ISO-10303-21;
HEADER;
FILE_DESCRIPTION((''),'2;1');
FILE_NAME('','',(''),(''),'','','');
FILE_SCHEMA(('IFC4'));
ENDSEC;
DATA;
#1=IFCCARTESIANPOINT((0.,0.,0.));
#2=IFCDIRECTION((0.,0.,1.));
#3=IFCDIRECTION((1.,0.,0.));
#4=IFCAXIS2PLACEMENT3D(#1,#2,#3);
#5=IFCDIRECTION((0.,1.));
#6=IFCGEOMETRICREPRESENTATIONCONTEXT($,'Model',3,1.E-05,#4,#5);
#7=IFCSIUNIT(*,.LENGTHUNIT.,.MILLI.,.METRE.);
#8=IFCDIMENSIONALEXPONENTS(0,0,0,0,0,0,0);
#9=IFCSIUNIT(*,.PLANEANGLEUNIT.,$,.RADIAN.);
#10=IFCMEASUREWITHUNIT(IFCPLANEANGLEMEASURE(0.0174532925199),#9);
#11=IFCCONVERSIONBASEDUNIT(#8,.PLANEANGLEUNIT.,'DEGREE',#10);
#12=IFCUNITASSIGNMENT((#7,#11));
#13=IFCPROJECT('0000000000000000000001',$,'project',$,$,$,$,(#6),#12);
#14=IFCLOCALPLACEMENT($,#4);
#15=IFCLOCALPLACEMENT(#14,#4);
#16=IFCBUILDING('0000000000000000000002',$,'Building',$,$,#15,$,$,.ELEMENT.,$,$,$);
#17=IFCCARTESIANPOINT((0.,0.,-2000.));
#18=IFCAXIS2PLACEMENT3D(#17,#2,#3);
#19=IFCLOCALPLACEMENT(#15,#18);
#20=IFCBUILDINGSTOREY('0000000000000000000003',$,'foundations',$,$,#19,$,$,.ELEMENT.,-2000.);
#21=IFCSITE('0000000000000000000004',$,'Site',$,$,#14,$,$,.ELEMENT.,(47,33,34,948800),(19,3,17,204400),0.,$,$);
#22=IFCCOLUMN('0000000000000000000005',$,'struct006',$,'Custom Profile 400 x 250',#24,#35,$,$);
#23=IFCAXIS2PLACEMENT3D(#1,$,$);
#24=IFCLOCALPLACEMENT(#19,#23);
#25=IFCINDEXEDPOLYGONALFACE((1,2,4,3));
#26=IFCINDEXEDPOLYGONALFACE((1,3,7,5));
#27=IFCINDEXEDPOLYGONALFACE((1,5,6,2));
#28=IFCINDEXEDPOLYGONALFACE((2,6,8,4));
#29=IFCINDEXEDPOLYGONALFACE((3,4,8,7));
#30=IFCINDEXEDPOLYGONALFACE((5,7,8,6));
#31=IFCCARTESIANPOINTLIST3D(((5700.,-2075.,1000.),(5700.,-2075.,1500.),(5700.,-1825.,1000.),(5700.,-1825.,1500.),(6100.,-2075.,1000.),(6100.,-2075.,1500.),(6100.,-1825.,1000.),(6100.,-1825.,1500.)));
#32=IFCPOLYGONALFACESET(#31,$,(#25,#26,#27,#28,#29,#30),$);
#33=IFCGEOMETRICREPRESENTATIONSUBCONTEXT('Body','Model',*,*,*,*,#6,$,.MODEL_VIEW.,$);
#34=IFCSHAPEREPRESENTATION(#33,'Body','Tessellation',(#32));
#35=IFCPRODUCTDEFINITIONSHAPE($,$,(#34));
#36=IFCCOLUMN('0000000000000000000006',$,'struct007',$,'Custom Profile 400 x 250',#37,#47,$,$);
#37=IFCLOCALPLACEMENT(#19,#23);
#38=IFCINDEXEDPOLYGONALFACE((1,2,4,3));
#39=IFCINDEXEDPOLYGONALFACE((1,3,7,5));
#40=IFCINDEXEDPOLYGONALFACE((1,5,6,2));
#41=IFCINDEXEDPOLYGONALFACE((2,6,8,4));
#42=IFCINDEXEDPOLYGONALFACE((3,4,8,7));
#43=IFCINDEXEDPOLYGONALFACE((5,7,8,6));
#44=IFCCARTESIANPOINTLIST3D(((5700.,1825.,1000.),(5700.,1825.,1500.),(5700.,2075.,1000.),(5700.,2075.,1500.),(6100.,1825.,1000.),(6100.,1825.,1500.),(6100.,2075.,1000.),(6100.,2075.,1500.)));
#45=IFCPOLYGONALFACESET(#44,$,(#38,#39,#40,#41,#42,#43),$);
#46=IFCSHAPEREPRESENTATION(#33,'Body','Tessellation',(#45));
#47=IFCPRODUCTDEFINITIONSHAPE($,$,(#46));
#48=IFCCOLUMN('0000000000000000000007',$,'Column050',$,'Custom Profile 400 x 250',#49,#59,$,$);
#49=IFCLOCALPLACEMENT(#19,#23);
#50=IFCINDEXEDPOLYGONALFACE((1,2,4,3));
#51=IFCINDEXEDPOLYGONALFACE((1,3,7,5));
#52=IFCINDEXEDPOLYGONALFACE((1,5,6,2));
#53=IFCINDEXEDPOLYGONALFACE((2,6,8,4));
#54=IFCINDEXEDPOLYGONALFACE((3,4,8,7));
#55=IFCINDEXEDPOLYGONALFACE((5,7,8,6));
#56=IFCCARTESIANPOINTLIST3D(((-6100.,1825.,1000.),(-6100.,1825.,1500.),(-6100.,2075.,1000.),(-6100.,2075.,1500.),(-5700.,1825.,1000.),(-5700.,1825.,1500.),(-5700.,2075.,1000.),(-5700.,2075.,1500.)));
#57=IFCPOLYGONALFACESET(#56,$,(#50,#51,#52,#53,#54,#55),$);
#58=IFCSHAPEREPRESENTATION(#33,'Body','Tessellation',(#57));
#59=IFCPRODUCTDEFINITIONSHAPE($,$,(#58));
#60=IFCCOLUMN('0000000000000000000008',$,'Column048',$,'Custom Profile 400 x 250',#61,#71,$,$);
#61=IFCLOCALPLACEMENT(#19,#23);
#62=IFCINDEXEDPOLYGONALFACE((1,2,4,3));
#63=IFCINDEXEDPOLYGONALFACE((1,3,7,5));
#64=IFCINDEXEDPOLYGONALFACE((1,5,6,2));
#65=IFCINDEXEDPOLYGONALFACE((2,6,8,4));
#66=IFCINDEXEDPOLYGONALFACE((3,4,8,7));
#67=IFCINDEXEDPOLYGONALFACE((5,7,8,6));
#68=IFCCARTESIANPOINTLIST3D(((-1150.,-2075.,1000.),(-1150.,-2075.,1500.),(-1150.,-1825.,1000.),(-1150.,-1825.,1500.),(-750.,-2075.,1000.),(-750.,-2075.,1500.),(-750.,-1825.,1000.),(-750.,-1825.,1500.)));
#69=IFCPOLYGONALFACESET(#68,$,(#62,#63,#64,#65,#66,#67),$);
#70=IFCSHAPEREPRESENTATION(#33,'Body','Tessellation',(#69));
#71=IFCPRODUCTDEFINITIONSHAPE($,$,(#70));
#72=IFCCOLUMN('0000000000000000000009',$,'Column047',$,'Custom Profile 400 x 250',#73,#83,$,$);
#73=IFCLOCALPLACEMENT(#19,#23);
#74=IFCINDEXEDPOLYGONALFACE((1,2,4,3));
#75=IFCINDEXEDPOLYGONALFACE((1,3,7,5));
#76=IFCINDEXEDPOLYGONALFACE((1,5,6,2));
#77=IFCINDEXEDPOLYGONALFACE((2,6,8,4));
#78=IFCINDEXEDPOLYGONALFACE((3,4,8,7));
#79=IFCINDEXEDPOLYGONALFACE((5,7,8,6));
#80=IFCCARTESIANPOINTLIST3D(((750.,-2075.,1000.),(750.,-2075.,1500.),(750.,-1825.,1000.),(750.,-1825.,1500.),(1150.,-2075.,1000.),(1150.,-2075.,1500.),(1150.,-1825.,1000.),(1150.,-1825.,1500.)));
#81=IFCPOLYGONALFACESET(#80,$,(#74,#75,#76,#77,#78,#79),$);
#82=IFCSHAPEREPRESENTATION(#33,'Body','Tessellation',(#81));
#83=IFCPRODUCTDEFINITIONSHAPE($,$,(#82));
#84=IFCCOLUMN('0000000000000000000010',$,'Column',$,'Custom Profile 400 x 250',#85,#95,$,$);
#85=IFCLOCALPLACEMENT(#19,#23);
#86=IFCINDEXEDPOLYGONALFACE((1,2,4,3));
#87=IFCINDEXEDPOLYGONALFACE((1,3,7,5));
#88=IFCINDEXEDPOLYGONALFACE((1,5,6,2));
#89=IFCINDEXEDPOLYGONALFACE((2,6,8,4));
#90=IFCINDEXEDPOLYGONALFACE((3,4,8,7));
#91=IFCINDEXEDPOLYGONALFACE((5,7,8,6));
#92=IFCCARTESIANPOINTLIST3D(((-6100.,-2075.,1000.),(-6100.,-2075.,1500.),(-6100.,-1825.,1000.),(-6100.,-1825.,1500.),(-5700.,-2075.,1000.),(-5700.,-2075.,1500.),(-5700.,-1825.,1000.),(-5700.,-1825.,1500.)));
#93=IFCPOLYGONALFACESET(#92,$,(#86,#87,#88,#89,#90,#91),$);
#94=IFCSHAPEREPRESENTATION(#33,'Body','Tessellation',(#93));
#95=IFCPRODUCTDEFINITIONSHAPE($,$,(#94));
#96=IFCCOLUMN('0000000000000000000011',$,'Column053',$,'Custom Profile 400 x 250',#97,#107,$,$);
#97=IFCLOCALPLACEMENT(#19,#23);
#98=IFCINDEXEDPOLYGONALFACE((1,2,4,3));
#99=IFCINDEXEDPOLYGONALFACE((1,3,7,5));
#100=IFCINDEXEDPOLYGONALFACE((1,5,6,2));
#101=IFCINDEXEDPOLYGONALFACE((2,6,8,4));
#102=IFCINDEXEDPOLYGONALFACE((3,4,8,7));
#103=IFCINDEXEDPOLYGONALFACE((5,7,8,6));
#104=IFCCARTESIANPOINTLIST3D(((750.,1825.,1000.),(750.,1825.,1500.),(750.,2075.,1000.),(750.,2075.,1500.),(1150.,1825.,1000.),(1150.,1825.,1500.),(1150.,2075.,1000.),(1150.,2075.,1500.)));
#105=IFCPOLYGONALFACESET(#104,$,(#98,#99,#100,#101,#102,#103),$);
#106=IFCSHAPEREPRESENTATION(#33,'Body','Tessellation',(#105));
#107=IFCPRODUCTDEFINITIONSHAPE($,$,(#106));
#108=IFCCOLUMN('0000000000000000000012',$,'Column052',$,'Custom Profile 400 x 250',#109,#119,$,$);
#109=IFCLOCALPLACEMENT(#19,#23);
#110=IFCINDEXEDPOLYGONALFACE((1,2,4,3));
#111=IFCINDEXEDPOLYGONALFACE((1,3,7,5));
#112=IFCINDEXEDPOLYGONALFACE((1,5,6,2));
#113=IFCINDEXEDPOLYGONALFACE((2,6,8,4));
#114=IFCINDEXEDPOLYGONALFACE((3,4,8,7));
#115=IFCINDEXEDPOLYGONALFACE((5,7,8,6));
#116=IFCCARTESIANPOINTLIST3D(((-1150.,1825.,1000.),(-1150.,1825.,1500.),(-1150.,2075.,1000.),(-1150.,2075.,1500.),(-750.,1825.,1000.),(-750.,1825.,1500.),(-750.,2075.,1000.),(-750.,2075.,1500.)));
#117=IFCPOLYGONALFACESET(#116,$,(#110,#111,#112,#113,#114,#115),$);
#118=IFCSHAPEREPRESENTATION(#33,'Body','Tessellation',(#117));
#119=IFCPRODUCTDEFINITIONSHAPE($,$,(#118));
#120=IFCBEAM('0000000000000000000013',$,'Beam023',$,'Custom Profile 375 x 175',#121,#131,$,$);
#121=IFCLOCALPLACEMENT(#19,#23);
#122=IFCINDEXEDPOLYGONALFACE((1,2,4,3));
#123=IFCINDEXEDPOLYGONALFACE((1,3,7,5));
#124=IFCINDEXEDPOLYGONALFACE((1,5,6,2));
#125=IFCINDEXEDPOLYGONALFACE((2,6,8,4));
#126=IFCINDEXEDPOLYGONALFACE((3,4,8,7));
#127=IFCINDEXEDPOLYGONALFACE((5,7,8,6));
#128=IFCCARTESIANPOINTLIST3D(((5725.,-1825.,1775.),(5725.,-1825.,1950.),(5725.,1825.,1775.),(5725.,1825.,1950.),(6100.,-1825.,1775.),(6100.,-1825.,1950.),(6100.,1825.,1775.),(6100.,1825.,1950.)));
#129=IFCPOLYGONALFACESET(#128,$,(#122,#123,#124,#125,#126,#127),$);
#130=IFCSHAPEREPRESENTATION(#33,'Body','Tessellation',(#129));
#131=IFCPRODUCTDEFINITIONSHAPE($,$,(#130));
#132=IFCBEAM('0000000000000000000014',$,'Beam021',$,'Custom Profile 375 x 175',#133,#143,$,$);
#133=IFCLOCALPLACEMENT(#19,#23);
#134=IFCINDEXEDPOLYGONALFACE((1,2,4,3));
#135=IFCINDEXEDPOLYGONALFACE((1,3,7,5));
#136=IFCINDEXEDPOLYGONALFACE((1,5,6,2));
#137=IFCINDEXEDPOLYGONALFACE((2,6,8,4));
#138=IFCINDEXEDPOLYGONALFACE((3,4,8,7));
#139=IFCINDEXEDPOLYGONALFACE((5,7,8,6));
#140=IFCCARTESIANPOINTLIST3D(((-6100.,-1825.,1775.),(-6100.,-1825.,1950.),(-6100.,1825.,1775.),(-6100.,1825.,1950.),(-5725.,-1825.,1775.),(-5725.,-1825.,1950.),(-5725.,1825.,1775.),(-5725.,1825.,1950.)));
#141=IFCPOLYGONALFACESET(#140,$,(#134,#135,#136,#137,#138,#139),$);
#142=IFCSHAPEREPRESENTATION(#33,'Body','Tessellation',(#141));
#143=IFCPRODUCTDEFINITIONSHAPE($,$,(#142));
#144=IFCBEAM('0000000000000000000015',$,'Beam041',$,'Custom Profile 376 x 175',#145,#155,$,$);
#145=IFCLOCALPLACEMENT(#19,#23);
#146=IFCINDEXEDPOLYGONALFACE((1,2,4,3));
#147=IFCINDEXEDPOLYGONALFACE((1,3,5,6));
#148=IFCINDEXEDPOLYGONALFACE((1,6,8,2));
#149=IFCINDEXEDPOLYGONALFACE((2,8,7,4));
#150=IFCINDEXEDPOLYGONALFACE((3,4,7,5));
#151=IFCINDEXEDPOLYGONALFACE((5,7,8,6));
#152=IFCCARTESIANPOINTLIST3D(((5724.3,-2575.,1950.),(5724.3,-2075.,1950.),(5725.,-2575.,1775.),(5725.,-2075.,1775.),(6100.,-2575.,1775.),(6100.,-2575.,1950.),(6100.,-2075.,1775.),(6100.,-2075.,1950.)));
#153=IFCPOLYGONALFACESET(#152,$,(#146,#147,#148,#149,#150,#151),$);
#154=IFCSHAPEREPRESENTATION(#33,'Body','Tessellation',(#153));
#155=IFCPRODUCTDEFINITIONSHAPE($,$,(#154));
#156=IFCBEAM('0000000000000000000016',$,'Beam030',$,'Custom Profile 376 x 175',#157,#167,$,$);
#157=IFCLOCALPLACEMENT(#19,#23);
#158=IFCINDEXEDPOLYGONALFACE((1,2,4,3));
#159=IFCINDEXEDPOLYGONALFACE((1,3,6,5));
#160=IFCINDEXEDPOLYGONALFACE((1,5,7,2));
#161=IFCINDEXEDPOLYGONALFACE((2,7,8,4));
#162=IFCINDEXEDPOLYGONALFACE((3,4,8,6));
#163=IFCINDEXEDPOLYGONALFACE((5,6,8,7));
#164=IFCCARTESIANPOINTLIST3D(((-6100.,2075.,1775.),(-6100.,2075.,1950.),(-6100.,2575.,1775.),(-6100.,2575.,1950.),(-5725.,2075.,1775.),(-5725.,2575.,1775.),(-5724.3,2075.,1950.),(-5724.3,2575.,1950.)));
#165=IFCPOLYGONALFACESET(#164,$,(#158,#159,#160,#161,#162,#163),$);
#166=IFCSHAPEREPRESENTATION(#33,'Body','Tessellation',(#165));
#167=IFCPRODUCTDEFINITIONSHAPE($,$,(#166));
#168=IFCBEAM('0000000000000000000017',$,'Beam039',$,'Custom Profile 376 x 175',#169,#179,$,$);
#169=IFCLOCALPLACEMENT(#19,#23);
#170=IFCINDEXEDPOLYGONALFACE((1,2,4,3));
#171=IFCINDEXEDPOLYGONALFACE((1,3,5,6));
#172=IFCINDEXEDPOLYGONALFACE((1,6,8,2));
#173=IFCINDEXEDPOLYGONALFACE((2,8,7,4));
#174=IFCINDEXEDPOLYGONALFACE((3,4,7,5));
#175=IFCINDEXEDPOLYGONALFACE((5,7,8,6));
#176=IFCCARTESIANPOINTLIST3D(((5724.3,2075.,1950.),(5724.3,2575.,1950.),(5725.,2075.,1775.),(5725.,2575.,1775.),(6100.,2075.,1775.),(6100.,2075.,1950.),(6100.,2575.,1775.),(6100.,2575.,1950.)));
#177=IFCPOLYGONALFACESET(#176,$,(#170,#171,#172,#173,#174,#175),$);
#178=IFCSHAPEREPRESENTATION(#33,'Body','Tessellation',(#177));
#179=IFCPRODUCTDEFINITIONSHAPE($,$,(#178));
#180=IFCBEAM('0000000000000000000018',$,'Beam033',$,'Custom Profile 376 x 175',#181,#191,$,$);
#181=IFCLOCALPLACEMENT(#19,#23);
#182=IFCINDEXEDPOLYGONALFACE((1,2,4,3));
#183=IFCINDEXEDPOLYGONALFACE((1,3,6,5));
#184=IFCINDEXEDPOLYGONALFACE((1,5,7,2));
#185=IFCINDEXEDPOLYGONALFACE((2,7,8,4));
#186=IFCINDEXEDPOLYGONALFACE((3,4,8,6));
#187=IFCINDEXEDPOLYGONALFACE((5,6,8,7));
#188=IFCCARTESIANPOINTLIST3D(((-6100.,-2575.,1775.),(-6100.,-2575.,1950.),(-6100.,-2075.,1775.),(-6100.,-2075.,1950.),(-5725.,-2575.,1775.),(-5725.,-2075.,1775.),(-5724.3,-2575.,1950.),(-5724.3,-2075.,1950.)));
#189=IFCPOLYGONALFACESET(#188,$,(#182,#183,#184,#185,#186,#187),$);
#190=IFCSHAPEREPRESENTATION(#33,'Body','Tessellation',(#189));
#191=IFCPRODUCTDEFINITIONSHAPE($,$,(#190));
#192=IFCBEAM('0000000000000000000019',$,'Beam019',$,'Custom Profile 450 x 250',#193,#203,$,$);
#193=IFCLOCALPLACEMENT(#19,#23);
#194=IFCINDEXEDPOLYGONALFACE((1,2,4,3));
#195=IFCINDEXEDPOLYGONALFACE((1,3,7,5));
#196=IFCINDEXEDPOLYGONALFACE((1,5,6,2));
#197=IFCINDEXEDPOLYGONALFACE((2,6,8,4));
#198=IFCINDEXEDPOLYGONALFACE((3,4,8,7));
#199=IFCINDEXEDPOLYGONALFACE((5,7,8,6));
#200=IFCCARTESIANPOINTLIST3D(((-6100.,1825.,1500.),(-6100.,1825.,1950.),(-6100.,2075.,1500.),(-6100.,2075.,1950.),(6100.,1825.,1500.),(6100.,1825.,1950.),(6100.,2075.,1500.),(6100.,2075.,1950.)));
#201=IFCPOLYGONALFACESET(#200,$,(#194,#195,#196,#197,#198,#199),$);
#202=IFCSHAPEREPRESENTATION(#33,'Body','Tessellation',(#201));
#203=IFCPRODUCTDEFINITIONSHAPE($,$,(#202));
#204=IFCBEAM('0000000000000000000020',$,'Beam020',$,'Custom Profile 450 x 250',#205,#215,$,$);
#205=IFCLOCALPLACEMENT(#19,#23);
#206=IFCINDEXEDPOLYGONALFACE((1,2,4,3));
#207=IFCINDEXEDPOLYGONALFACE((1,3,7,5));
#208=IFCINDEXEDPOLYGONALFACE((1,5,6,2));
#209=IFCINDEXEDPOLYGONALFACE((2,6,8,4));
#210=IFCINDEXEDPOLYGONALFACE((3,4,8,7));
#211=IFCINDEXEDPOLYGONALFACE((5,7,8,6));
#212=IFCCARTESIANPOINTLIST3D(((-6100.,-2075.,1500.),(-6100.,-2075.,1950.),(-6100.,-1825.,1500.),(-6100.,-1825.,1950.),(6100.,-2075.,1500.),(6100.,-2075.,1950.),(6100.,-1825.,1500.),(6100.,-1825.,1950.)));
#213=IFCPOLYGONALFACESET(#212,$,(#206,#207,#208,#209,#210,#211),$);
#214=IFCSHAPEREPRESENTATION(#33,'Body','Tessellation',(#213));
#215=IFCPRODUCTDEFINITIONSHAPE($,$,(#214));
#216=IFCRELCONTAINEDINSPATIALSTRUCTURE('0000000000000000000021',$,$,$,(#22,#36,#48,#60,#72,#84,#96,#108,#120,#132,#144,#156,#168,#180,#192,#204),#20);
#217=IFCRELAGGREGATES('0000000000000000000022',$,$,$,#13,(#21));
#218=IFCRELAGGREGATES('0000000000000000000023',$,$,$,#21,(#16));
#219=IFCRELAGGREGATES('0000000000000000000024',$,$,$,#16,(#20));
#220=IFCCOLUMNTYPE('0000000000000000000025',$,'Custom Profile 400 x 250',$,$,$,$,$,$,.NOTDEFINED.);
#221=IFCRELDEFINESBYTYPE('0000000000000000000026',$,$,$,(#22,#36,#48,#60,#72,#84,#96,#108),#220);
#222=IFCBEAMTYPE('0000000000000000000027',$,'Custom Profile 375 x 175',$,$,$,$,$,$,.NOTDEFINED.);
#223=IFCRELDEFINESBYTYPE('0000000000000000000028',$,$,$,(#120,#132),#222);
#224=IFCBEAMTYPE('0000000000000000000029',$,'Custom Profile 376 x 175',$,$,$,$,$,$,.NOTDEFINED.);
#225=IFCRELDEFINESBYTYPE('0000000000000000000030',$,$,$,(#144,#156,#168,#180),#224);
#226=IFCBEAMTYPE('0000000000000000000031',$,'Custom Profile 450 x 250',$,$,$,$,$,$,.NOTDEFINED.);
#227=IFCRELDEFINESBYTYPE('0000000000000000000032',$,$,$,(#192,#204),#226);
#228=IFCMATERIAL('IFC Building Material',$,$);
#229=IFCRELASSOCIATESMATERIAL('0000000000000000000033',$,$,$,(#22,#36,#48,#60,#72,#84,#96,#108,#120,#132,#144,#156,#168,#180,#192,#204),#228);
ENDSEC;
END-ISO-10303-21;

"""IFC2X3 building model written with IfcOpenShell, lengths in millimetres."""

from ifc_helpers import new_model, entity, si_unit, converted_unit, direction, frame, origin_with_axes, place, context, subcontext, project, spatial, polyline, outline, extrude, material, type_object, element, save


model = new_model("IFC2X3")

# Units and contexts
model_context = context("Model", 3, precision=1e-05, world=origin_with_axes(), true_north=direction((0.0, 1.0)))
body_context = subcontext(model_context, "Body", "Model", "MODEL_VIEW")
ifc_project = project(units=[si_unit("LENGTHUNIT", "METRE", prefix="MILLI"), converted_unit("PLANEANGLEUNIT", "DEGREE", entity("IfcPlaneAngleMeasure", 0.0174532925199), si_unit("PLANEANGLEUNIT", "RADIAN"), dimensions=[0, 0, 0, 0, 0, 0, 0])], contexts=[model_context])

# Site, building, storey
site_placement = place(None, origin_with_axes())
site = spatial("IfcSite", under=ifc_project, at=site_placement, Name="Site", CompositionType="ELEMENT", RefLatitude=(47, 33, 34, 948800), RefLongitude=(19, 3, 17, 204400), RefElevation=0.0)
building_placement = place(site_placement, origin_with_axes())
building = spatial("IfcBuilding", under=site, at=building_placement, Name="Building", CompositionType="ELEMENT")
storey_placement = place(building_placement, frame((0.0, 0.0, -2000.0), z_axis=(0.0, 0.0, 1.0), x_axis=(1.0, 0.0, 0.0)))
storey = spatial("IfcBuildingStorey", under=building, at=storey_placement, Name="foundations", CompositionType="ELEMENT", Elevation=-2000.0)

# Columns
ifc_material = material(Name="IFC Building Material")
column_type = type_object("IfcColumnType", Name="Custom Profile 400 x 250", PredefinedType="NOTDEFINED")
for number, where, z_axis, x_axis, name in (
    (1, (5900.0, -1950.0, 1000.0), (0.0, 0.0, 1.0), (1.0, 0.0, 0.0), "struct006"),
    (2, (5900.0, 1950.0, 1000.0), (0.0, 0.0, 1.0), (1.0, 0.0, 0.0), "struct007"),
    (3, (-5900.0, 1950.0, 1000.0), (0.0, 0.0, 1.0), (1.0, 0.0, 0.0), "Column050"),
    (4, (-950.0, -1950.0, 1000.0), (0.0, 0.0, 1.0), (1.0, 0.0, 0.0), "Column048"),
    (5, (950.0, -1950.0, 1000.0), (0.0, 0.0, 1.0), (1.0, 0.0, 0.0), "Column047"),
    (6, (-5900.0, -1950.0, 1000.0), (0.0, 0.0, 1.0), (1.0, 0.0, 0.0), "Column"),
    (7, (950.0, 1950.0, 1000.0), (0.0, 0.0, 1.0), (1.0, 0.0, 0.0), "Column053"),
    (8, (-950.0, 1950.0, 1000.0), (0.0, 0.0, 1.0), (1.0, 0.0, 0.0), "Column052"),
):
    element("IfcColumn", number, at=place(storey_placement, frame(where, z_axis=z_axis, x_axis=x_axis)), inside=storey, type_object=column_type, material=ifc_material, Name=name, ObjectType="Custom Profile 400 x 250", context=body_context, shape_type="SweptSolid", body=[
        extrude(outline(polyline([(-200.0, -125.0), (200.0, -125.0), (200.0, 125.0), (-200.0, 125.0), (-200.0, -125.0)])), origin_with_axes(), (0.0, 0.0, 1.0), 500.0),
    ])

# Beams
beam_type_1 = type_object("IfcBeamType", Name="Custom Profile 375 x 175", PredefinedType="NOTDEFINED")
for number, where, z_axis, x_axis, name in (
    (9, (5912.7, -1825.0, 1862.5), (0.0, 0.0, 1.0), (1.0, 0.0, 0.0), "Beam023"),
    (10, (-5912.3, -1825.0, 1862.5), (0.0, 0.0, 1.0), (1.0, 0.0, 0.0), "Beam021"),
):
    element("IfcBeam", number, at=place(storey_placement, frame(where, z_axis=z_axis, x_axis=x_axis)), inside=storey, type_object=beam_type_1, material=ifc_material, Name=name, ObjectType="Custom Profile 375 x 175", context=body_context, shape_type="SweptSolid", body=[
        extrude(outline(polyline([(-187.7, -87.5), (187.3, -87.5), (187.3, 87.5), (-187.7, 87.5), (-187.7, -87.5)])), frame((0.0, 3650.0, 0.0), z_axis=(0.0, -1.0, 0.0), x_axis=(1.0, 0.0, 0.0)), (0.0, 0.0, 1.0), 3650.0),
    ])
beam_type_2 = type_object("IfcBeamType", Name="Custom Profile 376 x 175", PredefinedType="NOTDEFINED")
beam_1_placement = place(storey_placement, frame((5912.3, -2075.0, 1862.5), z_axis=(0.0, 0.0, 1.0), x_axis=(-1.0, 0.0, 0.0)))
element("IfcBeam", 11, at=beam_1_placement, inside=storey, type_object=beam_type_2, material=ifc_material, Name="Beam041", ObjectType="Custom Profile 376 x 175", context=body_context, shape_type="SweptSolid", body=[
    extrude(outline(polyline([(-187.7, 87.5), (-187.7, -87.5), (187.3, -87.5), (188.0, 87.5), (-187.7, 87.5)])), frame((0.0, 500.0, 0.0), z_axis=(0.0, -1.0, 0.0), x_axis=(1.0, 0.0, 0.0)), (0.0, 0.0, 1.0), 500.0),
])
beam_2_placement = place(storey_placement, frame((-5912.3, 2075.0, 1862.5), z_axis=(0.0, 0.0, 1.0), x_axis=(1.0, 0.0, 0.0)))
element("IfcBeam", 12, at=beam_2_placement, inside=storey, type_object=beam_type_2, material=ifc_material, Name="Beam030", ObjectType="Custom Profile 376 x 175", context=body_context, shape_type="SweptSolid", body=[
    extrude(outline(polyline([(-187.7, -87.5), (187.3, -87.5), (188.0, 87.5), (-187.7, 87.5), (-187.7, -87.5)])), frame((0.0, 500.0, 0.0), z_axis=(0.0, -1.0, 0.0), x_axis=(1.0, 0.0, 0.0)), (0.0, 0.0, 1.0), 500.0),
])
beam_3_placement = place(storey_placement, frame((5912.3, 2575.0, 1862.5), z_axis=(0.0, 0.0, 1.0), x_axis=(-1.0, 0.0, 0.0)))
element("IfcBeam", 13, at=beam_3_placement, inside=storey, type_object=beam_type_2, material=ifc_material, Name="Beam039", ObjectType="Custom Profile 376 x 175", context=body_context, shape_type="SweptSolid", body=[
    extrude(outline(polyline([(-187.7, 87.5), (-187.7, -87.5), (187.3, -87.5), (188.0, 87.5), (-187.7, 87.5)])), frame((0.0, 500.0, 0.0), z_axis=(0.0, -1.0, 0.0), x_axis=(1.0, 0.0, 0.0)), (0.0, 0.0, 1.0), 500.0),
])
beam_4_placement = place(storey_placement, frame((-5912.3, -2575.0, 1862.5), z_axis=(0.0, 0.0, 1.0), x_axis=(1.0, 0.0, 0.0)))
element("IfcBeam", 14, at=beam_4_placement, inside=storey, type_object=beam_type_2, material=ifc_material, Name="Beam033", ObjectType="Custom Profile 376 x 175", context=body_context, shape_type="SweptSolid", body=[
    extrude(outline(polyline([(-187.7, -87.5), (187.3, -87.5), (188.0, 87.5), (-187.7, 87.5), (-187.7, -87.5)])), frame((0.0, 500.0, 0.0), z_axis=(0.0, -1.0, 0.0), x_axis=(1.0, 0.0, 0.0)), (0.0, 0.0, 1.0), 500.0),
])
beam_type_3 = type_object("IfcBeamType", Name="Custom Profile 450 x 250", PredefinedType="NOTDEFINED")
for number, where, z_axis, x_axis, name in (
    (15, (-6100.0, 1950.0, 1725.0), (0.0, 0.0, 1.0), (0.0, -1.0, 0.0), "Beam019"),
    (16, (-6100.0, -1950.0, 1725.0), (0.0, 0.0, 1.0), (0.0, -1.0, 0.0), "Beam020"),
):
    element("IfcBeam", number, at=place(storey_placement, frame(where, z_axis=z_axis, x_axis=x_axis)), inside=storey, type_object=beam_type_3, material=ifc_material, Name=name, ObjectType="Custom Profile 450 x 250", context=body_context, shape_type="SweptSolid", body=[
        extrude(outline(polyline([(-125.0, -225.0), (125.0, -225.0), (125.0, 225.0), (-125.0, 225.0), (-125.0, -225.0)])), frame((0.0, 12200.0, 0.0), z_axis=(0.0, -1.0, 0.0), x_axis=(1.0, 0.0, 0.0)), (0.0, 0.0, 1.0), 12200.0),
    ])

save(model, "model.ifc")
